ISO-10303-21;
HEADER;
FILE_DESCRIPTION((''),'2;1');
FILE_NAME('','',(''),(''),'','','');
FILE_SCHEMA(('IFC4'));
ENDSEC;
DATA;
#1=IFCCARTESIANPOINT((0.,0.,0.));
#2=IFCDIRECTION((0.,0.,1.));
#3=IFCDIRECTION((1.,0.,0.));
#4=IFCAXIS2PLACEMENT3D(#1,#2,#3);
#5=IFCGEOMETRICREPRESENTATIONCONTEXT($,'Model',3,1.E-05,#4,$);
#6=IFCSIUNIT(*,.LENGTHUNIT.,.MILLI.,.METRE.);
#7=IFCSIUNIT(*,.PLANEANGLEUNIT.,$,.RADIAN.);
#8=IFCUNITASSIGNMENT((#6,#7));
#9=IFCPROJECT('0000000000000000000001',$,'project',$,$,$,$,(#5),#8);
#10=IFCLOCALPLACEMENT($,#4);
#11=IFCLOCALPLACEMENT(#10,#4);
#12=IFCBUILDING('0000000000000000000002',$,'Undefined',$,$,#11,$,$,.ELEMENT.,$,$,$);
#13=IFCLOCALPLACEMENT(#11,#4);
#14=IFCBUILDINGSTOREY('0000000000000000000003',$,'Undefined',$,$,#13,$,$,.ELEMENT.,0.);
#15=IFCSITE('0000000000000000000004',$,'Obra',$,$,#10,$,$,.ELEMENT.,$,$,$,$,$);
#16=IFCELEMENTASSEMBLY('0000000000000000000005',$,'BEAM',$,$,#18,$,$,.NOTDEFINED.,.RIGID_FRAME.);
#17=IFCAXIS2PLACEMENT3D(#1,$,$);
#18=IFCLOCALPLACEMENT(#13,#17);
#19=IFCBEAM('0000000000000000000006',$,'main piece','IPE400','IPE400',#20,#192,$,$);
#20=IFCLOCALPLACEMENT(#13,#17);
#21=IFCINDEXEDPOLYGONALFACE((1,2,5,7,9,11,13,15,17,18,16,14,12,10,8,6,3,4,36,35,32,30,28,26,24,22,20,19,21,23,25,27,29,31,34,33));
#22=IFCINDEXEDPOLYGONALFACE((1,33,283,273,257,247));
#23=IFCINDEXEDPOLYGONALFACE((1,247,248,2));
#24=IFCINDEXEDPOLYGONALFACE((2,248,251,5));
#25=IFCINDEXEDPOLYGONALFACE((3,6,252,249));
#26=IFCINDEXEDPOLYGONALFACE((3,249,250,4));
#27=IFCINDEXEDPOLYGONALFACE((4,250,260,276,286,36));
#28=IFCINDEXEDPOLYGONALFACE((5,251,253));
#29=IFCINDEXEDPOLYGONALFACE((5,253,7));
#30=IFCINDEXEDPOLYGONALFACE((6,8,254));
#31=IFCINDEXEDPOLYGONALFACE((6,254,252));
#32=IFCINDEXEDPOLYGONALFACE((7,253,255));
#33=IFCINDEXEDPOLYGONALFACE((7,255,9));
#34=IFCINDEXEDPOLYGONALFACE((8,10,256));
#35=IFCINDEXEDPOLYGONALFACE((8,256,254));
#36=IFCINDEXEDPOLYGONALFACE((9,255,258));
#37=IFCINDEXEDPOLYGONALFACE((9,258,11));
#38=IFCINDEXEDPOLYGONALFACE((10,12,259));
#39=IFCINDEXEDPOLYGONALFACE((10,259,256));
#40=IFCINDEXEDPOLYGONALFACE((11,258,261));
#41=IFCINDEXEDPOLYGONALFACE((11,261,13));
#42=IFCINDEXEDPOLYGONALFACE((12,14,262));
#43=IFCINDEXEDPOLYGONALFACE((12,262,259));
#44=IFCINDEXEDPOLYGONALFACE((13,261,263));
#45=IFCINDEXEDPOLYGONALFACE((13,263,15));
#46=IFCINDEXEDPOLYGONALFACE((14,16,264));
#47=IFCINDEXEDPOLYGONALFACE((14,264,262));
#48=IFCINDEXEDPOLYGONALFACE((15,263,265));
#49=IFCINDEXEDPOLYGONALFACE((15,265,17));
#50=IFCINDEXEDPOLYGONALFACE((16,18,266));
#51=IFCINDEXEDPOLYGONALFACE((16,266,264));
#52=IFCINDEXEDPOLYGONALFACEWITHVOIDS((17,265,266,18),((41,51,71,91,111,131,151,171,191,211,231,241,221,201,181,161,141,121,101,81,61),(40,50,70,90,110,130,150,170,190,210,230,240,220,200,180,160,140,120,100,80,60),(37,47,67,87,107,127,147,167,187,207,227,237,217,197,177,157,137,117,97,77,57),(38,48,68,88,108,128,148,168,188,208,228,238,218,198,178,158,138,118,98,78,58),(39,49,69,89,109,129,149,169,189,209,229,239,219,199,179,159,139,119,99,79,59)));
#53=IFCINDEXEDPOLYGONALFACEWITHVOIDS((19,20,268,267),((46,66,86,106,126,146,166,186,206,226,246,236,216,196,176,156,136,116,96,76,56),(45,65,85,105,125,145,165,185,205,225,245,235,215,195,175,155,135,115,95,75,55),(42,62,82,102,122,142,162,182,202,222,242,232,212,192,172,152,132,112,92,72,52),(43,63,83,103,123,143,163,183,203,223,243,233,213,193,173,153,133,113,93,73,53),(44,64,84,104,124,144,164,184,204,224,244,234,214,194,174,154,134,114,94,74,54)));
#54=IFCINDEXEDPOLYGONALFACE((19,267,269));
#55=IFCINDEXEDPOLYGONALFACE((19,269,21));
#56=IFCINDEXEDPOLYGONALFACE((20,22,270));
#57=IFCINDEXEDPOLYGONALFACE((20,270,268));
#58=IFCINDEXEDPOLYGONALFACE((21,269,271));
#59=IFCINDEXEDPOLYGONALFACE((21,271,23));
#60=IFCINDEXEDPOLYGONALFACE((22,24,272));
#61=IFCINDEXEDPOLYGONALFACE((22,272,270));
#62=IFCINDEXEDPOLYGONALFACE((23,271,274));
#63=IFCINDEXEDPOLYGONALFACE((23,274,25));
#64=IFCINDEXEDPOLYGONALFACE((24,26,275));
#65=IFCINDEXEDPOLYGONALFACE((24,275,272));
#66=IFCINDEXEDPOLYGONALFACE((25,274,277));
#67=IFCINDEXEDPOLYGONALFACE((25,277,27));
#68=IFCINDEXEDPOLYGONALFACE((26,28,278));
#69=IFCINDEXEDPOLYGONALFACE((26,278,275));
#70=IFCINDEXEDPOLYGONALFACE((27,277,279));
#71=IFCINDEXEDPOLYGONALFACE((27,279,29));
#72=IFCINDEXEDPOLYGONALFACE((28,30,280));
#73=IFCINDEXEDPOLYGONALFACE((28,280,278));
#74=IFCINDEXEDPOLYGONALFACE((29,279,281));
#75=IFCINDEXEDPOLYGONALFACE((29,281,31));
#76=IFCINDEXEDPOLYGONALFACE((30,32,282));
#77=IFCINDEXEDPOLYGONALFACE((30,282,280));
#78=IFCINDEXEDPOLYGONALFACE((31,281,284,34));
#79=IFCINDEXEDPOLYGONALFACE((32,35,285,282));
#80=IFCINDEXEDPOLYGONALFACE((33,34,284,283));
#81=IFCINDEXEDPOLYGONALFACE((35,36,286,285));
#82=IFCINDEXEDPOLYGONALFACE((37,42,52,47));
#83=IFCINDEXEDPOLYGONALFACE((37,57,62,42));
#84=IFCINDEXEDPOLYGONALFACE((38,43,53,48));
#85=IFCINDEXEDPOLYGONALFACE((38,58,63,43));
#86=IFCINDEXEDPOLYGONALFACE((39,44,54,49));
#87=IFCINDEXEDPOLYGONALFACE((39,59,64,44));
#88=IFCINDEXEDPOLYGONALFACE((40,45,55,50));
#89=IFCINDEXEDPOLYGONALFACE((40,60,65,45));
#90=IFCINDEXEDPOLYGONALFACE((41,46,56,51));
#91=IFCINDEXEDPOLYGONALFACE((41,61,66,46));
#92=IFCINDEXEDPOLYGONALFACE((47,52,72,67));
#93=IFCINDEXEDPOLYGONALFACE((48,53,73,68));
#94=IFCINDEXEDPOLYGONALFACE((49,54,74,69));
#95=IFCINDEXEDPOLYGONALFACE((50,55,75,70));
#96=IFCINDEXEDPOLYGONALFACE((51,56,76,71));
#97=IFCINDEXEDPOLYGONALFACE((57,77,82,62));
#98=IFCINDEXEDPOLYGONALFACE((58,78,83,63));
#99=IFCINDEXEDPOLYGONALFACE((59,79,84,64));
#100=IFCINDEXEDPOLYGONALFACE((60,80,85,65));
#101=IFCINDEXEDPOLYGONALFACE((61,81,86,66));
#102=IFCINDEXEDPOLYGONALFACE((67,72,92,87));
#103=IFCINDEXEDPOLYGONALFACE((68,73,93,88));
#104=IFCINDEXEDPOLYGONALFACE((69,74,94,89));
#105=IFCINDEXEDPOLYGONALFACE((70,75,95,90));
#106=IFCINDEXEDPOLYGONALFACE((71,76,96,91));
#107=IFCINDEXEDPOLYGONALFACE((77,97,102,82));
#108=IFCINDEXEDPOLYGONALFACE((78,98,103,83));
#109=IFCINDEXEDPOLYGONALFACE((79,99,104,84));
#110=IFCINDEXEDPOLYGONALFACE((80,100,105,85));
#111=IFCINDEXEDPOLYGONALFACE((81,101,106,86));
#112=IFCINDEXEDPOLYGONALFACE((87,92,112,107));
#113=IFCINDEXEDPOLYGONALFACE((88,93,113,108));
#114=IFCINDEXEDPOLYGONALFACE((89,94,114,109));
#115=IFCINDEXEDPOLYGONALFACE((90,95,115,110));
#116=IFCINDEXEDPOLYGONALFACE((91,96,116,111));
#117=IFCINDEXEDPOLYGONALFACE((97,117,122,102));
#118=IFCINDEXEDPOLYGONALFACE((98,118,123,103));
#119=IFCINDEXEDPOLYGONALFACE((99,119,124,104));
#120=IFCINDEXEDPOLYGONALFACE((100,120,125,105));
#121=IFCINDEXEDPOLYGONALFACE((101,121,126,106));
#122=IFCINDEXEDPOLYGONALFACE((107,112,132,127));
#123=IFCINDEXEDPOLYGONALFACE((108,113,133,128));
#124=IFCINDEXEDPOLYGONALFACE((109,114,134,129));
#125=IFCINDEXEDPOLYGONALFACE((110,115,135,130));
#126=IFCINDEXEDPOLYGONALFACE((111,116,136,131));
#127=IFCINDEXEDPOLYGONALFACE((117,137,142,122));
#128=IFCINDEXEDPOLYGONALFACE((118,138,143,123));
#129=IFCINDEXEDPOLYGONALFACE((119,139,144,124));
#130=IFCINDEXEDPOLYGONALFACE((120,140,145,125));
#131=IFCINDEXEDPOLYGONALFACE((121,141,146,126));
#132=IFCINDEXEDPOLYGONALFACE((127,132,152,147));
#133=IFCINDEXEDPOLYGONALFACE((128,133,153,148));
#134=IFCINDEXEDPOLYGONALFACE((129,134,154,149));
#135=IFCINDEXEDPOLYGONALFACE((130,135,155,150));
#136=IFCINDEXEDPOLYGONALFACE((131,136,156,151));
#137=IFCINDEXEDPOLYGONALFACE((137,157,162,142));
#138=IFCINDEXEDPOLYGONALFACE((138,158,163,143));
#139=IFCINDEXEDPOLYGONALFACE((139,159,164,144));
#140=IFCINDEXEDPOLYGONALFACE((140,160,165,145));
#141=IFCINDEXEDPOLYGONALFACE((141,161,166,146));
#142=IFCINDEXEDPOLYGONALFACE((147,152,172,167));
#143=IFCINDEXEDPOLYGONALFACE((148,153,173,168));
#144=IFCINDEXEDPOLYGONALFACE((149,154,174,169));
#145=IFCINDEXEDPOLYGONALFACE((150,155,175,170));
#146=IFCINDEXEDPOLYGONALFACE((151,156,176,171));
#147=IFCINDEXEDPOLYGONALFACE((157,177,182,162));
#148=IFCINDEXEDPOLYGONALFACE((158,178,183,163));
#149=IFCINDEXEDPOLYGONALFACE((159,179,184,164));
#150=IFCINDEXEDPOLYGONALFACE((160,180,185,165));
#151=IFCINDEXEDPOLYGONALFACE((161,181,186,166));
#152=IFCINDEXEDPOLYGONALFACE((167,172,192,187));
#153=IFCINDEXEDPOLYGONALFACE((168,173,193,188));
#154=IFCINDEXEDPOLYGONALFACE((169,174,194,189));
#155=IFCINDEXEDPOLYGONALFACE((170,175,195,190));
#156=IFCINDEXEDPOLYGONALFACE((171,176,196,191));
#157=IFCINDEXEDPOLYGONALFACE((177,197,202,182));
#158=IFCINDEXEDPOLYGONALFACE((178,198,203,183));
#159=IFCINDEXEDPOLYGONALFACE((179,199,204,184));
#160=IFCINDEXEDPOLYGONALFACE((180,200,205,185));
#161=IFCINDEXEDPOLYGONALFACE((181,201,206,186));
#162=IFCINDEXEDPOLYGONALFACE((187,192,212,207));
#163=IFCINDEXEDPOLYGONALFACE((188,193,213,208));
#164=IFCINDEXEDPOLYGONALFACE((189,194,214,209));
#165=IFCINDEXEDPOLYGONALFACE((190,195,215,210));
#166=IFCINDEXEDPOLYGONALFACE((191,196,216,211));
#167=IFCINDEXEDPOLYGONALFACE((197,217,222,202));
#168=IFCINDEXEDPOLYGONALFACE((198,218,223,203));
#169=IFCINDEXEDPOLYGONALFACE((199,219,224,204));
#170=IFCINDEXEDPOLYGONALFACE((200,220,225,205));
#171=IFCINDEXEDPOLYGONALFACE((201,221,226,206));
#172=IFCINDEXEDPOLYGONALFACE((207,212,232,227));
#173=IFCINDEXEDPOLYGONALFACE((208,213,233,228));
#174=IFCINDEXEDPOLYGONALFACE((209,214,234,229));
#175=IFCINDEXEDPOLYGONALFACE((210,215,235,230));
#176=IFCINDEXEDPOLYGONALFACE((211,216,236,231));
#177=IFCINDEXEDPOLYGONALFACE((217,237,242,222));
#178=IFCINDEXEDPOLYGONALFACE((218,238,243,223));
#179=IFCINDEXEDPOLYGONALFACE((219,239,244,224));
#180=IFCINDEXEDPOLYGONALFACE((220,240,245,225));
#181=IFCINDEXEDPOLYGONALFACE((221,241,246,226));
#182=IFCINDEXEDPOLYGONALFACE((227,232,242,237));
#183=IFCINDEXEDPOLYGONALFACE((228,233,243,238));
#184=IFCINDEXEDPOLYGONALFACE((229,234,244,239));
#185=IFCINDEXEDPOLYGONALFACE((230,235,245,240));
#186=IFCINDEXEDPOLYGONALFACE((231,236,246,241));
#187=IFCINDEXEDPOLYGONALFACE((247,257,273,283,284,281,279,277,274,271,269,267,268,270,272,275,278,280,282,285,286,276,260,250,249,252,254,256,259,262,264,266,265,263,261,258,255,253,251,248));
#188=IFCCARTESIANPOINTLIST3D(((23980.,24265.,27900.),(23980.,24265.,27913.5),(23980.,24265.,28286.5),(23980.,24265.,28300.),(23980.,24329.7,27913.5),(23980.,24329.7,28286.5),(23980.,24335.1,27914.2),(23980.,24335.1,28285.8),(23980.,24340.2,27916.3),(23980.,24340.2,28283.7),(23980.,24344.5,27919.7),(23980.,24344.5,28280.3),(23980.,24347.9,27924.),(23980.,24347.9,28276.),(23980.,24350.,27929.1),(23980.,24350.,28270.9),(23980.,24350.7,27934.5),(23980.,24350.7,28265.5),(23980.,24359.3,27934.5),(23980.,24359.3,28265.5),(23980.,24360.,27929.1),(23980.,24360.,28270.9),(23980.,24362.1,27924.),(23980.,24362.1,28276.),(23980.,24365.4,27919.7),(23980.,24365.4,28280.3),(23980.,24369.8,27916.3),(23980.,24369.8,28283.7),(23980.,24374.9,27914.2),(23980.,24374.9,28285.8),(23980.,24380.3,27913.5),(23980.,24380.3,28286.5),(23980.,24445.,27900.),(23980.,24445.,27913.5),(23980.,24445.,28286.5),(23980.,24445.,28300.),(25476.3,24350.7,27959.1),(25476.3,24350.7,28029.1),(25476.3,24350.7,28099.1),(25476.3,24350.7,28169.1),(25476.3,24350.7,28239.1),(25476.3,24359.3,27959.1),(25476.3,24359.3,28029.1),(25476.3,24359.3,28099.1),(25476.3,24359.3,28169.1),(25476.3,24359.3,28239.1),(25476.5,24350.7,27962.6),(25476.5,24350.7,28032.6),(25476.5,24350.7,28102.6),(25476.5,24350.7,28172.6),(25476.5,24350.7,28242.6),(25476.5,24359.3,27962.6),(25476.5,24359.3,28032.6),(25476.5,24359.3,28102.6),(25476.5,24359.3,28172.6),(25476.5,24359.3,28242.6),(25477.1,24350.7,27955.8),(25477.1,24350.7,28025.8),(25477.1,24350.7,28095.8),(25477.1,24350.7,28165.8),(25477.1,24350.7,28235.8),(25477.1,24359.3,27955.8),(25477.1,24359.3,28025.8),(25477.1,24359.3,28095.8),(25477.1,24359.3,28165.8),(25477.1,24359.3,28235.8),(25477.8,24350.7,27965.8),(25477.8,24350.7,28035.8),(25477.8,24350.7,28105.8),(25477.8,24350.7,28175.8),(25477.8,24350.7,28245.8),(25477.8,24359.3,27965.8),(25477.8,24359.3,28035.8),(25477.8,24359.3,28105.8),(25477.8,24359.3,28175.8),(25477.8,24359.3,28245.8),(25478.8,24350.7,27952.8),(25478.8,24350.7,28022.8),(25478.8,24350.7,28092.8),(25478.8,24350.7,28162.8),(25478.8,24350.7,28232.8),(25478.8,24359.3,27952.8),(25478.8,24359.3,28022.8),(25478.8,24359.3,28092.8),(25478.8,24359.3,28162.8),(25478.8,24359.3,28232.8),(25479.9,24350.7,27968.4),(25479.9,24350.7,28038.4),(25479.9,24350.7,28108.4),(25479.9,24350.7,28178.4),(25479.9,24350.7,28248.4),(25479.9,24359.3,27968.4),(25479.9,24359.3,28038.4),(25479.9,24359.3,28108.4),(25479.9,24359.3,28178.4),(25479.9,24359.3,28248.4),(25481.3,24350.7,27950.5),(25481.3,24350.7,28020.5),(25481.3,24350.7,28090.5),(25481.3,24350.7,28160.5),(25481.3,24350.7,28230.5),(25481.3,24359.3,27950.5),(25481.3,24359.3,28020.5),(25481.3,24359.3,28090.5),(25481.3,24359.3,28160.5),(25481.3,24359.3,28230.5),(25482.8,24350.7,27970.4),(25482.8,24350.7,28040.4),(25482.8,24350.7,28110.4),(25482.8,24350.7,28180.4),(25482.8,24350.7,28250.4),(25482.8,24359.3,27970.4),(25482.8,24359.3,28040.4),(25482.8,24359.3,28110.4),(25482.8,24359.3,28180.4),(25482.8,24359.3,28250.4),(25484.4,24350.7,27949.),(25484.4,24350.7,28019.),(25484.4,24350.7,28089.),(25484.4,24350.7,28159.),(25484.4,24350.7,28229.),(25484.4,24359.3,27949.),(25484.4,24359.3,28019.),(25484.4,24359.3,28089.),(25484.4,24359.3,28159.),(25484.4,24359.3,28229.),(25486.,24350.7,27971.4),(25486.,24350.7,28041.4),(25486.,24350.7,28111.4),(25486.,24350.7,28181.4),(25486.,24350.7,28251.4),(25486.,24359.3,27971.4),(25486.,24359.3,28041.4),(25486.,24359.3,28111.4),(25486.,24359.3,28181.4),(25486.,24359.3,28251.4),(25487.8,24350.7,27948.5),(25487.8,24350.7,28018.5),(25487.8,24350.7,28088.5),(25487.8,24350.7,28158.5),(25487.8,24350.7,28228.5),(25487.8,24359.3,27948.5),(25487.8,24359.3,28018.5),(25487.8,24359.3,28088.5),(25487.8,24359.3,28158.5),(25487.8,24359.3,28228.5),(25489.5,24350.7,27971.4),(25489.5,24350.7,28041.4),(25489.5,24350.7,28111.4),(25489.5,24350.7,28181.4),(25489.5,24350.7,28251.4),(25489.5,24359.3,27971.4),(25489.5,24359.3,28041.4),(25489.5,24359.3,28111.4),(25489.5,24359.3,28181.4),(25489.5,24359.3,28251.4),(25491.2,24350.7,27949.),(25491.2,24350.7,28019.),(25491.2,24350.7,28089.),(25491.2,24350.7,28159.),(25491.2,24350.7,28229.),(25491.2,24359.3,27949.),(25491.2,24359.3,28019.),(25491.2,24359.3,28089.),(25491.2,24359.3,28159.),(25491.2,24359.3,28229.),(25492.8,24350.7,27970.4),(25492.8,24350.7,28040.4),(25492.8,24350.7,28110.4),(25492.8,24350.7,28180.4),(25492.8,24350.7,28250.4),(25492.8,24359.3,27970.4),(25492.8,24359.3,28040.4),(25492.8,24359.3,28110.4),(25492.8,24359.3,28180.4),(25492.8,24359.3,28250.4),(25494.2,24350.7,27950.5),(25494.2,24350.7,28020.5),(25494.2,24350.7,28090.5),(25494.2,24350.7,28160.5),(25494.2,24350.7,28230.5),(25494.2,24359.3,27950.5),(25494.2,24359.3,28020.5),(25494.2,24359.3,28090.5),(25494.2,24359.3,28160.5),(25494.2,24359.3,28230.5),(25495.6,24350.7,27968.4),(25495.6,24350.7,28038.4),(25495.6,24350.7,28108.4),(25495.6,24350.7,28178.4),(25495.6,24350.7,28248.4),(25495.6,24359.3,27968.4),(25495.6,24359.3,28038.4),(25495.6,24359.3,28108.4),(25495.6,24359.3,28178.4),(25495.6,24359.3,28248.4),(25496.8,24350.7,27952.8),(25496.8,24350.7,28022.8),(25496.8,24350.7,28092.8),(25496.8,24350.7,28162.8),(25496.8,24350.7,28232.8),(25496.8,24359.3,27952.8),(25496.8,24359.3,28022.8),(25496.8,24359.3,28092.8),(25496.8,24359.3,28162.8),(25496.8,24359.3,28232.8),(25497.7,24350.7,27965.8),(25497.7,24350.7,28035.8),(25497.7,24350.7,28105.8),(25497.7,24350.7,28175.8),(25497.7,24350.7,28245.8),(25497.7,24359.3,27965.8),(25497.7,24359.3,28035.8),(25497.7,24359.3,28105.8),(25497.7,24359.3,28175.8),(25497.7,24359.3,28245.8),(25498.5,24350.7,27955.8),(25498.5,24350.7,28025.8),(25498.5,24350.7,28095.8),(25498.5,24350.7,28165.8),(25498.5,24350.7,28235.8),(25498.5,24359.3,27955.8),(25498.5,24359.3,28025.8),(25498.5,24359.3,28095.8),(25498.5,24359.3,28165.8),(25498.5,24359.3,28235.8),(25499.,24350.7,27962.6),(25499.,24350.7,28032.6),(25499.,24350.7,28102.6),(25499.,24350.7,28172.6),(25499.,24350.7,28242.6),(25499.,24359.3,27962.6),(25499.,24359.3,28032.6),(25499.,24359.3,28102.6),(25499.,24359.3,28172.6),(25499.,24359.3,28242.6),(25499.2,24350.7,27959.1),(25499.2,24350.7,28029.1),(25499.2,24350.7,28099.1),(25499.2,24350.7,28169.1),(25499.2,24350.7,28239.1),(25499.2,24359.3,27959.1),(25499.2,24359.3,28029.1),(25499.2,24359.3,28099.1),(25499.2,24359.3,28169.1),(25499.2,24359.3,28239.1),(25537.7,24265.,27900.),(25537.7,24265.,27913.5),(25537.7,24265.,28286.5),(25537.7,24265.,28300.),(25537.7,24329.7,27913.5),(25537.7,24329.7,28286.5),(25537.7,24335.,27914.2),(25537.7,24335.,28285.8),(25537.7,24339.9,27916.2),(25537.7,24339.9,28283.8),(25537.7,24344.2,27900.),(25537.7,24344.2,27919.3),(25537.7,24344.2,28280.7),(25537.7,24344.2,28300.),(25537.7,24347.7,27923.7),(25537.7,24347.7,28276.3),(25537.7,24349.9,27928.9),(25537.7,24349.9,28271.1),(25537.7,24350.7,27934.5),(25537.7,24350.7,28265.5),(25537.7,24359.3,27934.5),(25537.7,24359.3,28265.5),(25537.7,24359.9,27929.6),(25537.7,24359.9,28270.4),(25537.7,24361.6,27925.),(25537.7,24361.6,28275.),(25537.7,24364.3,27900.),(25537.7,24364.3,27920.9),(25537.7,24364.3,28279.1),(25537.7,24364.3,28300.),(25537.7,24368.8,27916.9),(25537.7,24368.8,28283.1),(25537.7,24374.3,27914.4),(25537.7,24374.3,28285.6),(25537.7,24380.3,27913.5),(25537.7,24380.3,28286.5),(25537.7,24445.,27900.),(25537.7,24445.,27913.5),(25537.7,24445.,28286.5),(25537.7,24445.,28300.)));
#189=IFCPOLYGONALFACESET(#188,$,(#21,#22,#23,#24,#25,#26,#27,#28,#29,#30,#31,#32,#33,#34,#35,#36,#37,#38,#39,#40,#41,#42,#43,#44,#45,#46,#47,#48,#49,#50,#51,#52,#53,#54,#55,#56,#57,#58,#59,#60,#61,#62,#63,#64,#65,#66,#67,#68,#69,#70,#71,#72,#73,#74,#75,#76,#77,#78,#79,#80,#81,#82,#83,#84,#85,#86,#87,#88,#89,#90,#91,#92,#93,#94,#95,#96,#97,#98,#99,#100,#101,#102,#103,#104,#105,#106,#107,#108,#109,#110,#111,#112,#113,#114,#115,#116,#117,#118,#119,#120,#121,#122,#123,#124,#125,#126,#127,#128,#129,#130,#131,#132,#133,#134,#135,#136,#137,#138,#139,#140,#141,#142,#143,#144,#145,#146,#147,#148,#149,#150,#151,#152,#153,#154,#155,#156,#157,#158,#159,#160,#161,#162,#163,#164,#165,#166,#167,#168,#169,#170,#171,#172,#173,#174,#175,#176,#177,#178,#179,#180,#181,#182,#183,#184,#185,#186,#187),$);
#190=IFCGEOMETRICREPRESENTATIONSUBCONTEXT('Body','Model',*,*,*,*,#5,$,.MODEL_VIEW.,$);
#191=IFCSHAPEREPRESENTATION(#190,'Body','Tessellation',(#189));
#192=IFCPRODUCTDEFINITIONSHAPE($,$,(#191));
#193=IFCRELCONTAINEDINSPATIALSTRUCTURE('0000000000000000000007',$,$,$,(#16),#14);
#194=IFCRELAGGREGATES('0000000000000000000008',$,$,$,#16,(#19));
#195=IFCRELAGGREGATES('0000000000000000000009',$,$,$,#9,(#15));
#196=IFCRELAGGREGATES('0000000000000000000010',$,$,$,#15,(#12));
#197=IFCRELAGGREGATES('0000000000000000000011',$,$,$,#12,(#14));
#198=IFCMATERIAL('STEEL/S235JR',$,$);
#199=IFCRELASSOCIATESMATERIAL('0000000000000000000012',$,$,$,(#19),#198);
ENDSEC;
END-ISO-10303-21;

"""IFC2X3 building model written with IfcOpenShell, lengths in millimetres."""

from ifc_helpers import new_model, si_unit, frame, origin_with_axes, origin_2d_with_axis, place, context, subcontext, project, spatial, rectangle, circle, i_section, extrude, clip, halfspace, source, transform, mapped, material, element, aggregate, save


model = new_model("IFC2X3")

# Units and contexts
model_context = context("Model", 3, precision=1e-05, world=origin_with_axes())
body_context = subcontext(model_context, "Body", "Model", "MODEL_VIEW")
ifc_project = project(units=[si_unit("LENGTHUNIT", "METRE", prefix="MILLI"), si_unit("PLANEANGLEUNIT", "RADIAN")], contexts=[model_context])

# Site, building, storey
site_placement = place(None, origin_with_axes())
site = spatial("IfcSite", under=ifc_project, at=site_placement, Name="Obra", CompositionType="ELEMENT")
building_placement = place(site_placement, origin_with_axes())
building = spatial("IfcBuilding", under=site, at=building_placement, Name="Undefined", CompositionType="ELEMENT")
storey_placement = place(building_placement, origin_with_axes())
storey = spatial("IfcBuildingStorey", under=building, at=storey_placement, Name="Undefined", CompositionType="ELEMENT", Elevation=0.0)

# Element assembly, beam, openings
ifc_material = material(Name="STEEL/S235JR")
assembly_1_placement = place(storey_placement, origin_with_axes())
assembly_1 = element("IfcElementAssembly", 1, at=assembly_1_placement, inside=storey, Name="BEAM", AssemblyPlace="NOTDEFINED", PredefinedType="RIGID_FRAME")
beam_1_placement = place(assembly_1_placement, frame((23980.0, 24355.0, 28100.0), z_axis=(0.0, 0.0, 1.0), x_axis=(1.0, 0.000002, 0.0)))
beam_1 = element("IfcBeam", 2, at=beam_1_placement, material=ifc_material, Name="main piece", Description="IPE400", ObjectType="IPE400", context=body_context, shape_type="Clipping", body=[
    clip(extrude(i_section(OverallWidth=180.0, OverallDepth=400.0, WebThickness=8.6, FlangeThickness=13.5, FilletRadius=21.0, at=origin_2d_with_axis()), frame((1557.8, 0.0, 0.0), z_axis=(-1.0, 0.0, 0.0), x_axis=(0.0, -1.0, 0.0)), (0.0, 0.0, 1.0), 1557.8), halfspace(frame((1557.8, 0.0, -300.0), z_axis=(-1.0, 0.000002, 0.0), x_axis=(0.000001, 1.0, 0.0)), True)),
])
opening_1_placement = place(assembly_1_placement, frame((23980.0, 24355.0, 28100.0), z_axis=(0.0, 0.0, 1.0), x_axis=(1.0, 0.000002, 0.0)))
element("IfcOpeningElement", 3, at=opening_1_placement, cuts=beam_1, ObjectType="Recess", context=body_context, shape_type="SweptSolid", body=[
    extrude(rectangle(XDim=12.1, YDim=100.3, at=origin_2d_with_axis()), frame((1563.7, -40.9, 201.0), z_axis=(0.0, 0.0, -1.0), x_axis=(-1.0, 0.000002, 0.0)), (0.0, 0.0, 1.0), 402.0),
])
opening_2_placement = place(assembly_1_placement, frame((23980.0, 24355.0, 28100.0), z_axis=(0.0, 0.0, 1.0), x_axis=(1.0, 0.000002, 0.0)))
element("IfcOpeningElement", 4, at=opening_2_placement, cuts=beam_1, ObjectType="Recess", context=body_context, shape_type="SweptSolid", body=[
    extrude(rectangle(XDim=12.1, YDim=101.8, at=origin_2d_with_axis()), frame((1563.7, 40.1, 201.0), z_axis=(0.0, 0.0, -1.0), x_axis=(-1.0, 0.000002, 0.0)), (0.0, 0.0, 1.0), 402.0),
])
shared_shape_1 = source(origin_with_axes(), body_context, "Body", "SweptSolid", [
    extrude(circle(Radius=11.5, at=origin_2d_with_axis()), frame((0.0, -4.4, 0.0), z_axis=(0.0, 1.0, 0.0), x_axis=(1.0, 0.0, 0.0)), (0.0, 0.0, 1.0), 8.8),
])
opening_3_placement = place(assembly_1_placement, frame((25537.8, 24355.0, 28300.0), z_axis=(-1.0, 0.0, 0.0), x_axis=(0.0, 0.0, -1.0)))
element("IfcOpeningElement", 5, at=opening_3_placement, cuts=beam_1, ObjectType="Opening", context=body_context, shape_type="MappedRepresentation", body=[
    mapped(shared_shape_1, transform((60.0, 0.0, 50.0))),
    mapped(shared_shape_1, transform((130.0, 0.0, 50.0))),
    mapped(shared_shape_1, transform((200.0, 0.0, 50.0))),
    mapped(shared_shape_1, transform((270.0, 0.0, 50.0))),
    mapped(shared_shape_1, transform((340.0, 0.0, 50.0))),
])
aggregate(assembly_1, [beam_1])

save(model, "model.ifc")
